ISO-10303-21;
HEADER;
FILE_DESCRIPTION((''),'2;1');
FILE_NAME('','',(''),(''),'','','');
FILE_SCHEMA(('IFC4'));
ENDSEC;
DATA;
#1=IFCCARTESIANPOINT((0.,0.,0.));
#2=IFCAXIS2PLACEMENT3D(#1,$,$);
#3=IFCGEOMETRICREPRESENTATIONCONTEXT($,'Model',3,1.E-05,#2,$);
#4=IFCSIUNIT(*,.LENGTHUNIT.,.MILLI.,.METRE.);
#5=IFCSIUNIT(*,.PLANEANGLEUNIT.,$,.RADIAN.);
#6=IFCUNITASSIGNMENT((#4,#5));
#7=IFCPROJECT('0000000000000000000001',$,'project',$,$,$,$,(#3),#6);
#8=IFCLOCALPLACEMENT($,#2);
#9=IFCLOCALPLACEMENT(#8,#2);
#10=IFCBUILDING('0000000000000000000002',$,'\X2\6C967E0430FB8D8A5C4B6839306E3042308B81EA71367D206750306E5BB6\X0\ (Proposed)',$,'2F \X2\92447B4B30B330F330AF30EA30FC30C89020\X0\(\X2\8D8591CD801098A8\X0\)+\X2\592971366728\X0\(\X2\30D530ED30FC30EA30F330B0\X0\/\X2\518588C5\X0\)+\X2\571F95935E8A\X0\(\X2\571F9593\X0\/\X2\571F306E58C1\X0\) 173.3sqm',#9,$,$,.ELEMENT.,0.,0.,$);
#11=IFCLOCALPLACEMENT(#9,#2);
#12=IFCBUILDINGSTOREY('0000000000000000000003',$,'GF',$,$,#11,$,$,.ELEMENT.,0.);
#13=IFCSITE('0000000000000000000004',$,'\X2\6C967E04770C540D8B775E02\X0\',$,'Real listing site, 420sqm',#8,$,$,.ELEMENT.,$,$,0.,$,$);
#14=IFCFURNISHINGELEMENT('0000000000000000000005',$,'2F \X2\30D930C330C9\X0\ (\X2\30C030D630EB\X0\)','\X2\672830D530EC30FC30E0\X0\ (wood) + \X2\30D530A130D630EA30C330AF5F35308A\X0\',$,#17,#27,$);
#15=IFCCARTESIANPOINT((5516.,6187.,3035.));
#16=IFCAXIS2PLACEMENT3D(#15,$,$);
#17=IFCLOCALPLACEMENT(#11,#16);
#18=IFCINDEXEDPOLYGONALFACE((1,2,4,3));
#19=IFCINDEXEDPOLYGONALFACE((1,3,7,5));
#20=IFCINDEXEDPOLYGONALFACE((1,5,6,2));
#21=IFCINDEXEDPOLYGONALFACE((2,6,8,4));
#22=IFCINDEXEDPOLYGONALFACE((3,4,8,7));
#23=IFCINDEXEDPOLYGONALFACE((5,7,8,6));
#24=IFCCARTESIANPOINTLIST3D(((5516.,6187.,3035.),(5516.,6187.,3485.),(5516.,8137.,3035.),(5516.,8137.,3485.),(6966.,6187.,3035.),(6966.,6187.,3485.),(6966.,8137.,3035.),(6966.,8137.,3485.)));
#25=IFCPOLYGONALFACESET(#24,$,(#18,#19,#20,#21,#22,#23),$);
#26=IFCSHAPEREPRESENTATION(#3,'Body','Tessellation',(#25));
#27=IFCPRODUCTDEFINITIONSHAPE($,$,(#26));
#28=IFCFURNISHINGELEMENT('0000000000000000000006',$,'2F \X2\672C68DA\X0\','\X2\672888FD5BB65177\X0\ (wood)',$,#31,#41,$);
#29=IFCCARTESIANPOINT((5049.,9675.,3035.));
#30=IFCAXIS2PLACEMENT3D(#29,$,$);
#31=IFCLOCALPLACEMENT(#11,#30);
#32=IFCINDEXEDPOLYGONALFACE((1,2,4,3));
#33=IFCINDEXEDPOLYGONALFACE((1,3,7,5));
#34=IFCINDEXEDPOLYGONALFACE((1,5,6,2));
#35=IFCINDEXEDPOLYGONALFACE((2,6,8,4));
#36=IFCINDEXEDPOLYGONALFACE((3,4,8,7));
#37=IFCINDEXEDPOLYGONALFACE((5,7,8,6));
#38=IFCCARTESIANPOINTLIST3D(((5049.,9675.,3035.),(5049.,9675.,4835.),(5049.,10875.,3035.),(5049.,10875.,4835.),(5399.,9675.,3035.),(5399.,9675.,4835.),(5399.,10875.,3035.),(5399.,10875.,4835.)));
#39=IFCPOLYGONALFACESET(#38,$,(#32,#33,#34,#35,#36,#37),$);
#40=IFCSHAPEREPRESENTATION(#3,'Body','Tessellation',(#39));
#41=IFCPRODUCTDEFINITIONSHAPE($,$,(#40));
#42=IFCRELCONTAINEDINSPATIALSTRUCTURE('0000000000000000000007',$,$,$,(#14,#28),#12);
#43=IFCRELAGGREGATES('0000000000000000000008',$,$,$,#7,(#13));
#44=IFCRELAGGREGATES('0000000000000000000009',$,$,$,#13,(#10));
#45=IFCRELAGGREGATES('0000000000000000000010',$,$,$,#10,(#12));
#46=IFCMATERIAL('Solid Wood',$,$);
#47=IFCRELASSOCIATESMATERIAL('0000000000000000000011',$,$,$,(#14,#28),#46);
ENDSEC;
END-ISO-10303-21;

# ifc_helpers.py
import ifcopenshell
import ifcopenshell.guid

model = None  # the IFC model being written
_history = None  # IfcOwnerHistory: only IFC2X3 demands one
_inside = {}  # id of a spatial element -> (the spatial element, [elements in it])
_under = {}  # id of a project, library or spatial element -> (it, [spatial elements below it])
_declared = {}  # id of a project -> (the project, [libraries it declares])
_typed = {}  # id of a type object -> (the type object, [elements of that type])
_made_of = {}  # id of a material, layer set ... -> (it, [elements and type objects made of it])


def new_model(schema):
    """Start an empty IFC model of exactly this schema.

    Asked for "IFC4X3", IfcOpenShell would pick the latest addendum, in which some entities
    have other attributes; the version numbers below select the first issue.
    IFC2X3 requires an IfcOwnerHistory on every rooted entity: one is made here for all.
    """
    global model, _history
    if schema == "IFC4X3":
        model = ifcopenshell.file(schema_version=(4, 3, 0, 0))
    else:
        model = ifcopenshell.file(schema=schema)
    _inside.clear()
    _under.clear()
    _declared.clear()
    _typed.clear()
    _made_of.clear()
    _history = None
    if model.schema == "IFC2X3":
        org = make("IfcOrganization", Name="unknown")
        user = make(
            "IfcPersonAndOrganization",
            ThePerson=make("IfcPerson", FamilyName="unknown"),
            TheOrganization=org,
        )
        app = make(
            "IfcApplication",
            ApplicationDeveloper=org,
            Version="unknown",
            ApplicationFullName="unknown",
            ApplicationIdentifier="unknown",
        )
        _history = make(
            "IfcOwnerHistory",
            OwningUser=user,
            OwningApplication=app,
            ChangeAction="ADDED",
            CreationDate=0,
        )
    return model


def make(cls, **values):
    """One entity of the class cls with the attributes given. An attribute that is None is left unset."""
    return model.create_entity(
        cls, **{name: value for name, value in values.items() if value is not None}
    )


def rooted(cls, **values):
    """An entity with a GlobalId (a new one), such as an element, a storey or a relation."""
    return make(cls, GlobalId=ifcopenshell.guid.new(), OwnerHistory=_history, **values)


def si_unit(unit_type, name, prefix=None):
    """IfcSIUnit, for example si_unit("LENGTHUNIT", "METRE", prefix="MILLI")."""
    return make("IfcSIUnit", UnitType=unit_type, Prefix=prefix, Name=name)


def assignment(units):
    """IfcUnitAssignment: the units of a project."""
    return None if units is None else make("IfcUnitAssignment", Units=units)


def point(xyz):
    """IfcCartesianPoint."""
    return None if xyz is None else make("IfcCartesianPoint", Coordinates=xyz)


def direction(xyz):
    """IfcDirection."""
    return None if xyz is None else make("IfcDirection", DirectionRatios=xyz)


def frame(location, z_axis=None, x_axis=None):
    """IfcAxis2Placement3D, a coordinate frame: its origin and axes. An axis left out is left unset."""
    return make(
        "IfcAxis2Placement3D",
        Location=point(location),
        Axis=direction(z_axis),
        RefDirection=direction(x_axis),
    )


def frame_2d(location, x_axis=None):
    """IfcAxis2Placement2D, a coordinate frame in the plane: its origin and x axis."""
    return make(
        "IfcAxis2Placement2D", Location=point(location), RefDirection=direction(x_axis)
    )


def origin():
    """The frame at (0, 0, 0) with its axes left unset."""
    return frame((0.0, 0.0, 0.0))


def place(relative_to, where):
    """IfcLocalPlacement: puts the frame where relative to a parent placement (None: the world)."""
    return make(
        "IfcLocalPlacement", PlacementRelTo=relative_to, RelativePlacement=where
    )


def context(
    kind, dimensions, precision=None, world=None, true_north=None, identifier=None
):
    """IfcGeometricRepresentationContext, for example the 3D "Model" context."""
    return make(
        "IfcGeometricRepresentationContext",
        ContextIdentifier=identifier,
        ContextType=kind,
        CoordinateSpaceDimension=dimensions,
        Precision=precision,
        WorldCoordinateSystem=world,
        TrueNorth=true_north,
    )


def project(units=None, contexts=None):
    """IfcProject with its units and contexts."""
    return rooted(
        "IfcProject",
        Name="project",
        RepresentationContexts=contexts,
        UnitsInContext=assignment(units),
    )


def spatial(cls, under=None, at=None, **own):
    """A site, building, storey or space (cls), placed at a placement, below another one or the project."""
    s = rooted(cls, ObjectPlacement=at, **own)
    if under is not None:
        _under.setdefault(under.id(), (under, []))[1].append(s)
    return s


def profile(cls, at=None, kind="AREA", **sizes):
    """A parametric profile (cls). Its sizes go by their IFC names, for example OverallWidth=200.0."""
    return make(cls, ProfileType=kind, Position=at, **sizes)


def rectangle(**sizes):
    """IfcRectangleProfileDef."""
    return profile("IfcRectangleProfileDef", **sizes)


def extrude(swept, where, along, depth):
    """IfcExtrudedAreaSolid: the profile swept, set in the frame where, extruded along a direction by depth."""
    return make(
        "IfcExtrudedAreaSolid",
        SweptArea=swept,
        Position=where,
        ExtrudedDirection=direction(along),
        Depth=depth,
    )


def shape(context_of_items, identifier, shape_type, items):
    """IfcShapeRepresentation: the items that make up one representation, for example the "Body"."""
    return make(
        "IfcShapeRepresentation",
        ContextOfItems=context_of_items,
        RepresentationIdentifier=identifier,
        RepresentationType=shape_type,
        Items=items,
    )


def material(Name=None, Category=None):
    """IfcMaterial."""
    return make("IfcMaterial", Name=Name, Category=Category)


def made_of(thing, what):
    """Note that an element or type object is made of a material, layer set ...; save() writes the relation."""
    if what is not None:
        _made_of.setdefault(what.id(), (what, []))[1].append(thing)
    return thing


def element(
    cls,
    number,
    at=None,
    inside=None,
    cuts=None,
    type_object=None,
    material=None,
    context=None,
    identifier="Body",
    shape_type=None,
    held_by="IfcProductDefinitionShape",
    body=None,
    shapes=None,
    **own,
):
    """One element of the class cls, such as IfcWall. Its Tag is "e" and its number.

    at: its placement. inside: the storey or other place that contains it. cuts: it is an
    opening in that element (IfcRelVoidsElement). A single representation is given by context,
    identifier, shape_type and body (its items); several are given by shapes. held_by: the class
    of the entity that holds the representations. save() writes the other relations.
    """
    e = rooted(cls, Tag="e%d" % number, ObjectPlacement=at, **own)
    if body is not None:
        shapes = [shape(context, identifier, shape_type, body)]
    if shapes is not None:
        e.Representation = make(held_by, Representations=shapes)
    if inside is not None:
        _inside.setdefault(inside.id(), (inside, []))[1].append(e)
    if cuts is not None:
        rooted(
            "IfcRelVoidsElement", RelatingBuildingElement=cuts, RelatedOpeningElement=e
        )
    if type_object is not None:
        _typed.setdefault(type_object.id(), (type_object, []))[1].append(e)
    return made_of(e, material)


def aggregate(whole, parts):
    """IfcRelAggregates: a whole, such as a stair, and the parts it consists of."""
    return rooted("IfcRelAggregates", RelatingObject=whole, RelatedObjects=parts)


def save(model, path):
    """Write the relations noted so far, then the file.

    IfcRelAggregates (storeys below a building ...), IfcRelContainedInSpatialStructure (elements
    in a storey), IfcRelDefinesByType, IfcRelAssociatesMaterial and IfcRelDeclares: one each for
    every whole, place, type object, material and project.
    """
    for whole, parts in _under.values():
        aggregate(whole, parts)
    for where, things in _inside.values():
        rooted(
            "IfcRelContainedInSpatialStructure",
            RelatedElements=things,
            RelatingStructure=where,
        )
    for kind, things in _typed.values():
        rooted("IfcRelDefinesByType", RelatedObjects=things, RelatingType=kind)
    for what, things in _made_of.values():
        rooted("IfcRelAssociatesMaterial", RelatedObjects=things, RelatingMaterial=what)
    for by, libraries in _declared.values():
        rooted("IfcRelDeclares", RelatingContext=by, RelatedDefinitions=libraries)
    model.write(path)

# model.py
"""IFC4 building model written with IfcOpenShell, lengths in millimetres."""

from ifc_helpers import new_model, si_unit, frame, frame_2d, origin, place, context, project, spatial, rectangle, extrude, material, element, save


model = new_model("IFC4")

# Units and contexts
model_context = context("Model", 3, precision=1e-05, world=origin())
ifc_project = project(units=[si_unit("LENGTHUNIT", "METRE", prefix="MILLI"), si_unit("PLANEANGLEUNIT", "RADIAN")], contexts=[model_context])

# Site, building, storey
site_placement = place(None, origin())
site = spatial("IfcSite", under=ifc_project, at=site_placement, Name="沖縄県名護市", ObjectType="Real listing site, 420sqm", CompositionType="ELEMENT", RefElevation=0.0)
building_placement = place(site_placement, origin())
building = spatial("IfcBuilding", under=site, at=building_placement, Name="沖縄・越屋根のある自然素材の家 (Proposed)", ObjectType="2F 鉄筋コンクリート造(超重耐風)+天然木(フローリング/内装)+土間床(土間/土の壁) 173.3sqm", CompositionType="ELEMENT", ElevationOfRefHeight=0.0, ElevationOfTerrain=0.0)
storey_placement = place(building_placement, origin())
storey = spatial("IfcBuildingStorey", under=building, at=storey_placement, Name="GF", CompositionType="ELEMENT", Elevation=0.0)

# Shared definitions
ifc_material_1 = material(Name="Solid Wood")

# Furnishing elements
furnishing_1_placement = place(storey_placement, frame((5516.0, 6187.0, 3035.0)))
element("IfcFurnishingElement", 1, at=furnishing_1_placement, inside=storey, material=ifc_material_1, Name="2F ベッド (ダブル)", Description="木フレーム (wood) + ファブリック張り", context=model_context, shape_type="SweptSolid", body=[
    extrude(rectangle(XDim=1450.0, YDim=1950.0, at=frame_2d((725.0, 975.0))), frame((5516.0, 6187.0, 3035.0)), (0.0, 0.0, 1.0), 450.0),
])
furnishing_2_placement = place(storey_placement, frame((5049.0, 9675.0, 3035.0)))
element("IfcFurnishingElement", 2, at=furnishing_2_placement, inside=storey, material=ifc_material_1, Name="2F 本棚", Description="木製家具 (wood)", context=model_context, shape_type="SweptSolid", body=[
    extrude(rectangle(XDim=350.0, YDim=1200.0, at=frame_2d((175.0, 600.0))), frame((5049.0, 9675.0, 3035.0)), (0.0, 0.0, 1.0), 1800.0),
])

save(model, "model.ifc")
